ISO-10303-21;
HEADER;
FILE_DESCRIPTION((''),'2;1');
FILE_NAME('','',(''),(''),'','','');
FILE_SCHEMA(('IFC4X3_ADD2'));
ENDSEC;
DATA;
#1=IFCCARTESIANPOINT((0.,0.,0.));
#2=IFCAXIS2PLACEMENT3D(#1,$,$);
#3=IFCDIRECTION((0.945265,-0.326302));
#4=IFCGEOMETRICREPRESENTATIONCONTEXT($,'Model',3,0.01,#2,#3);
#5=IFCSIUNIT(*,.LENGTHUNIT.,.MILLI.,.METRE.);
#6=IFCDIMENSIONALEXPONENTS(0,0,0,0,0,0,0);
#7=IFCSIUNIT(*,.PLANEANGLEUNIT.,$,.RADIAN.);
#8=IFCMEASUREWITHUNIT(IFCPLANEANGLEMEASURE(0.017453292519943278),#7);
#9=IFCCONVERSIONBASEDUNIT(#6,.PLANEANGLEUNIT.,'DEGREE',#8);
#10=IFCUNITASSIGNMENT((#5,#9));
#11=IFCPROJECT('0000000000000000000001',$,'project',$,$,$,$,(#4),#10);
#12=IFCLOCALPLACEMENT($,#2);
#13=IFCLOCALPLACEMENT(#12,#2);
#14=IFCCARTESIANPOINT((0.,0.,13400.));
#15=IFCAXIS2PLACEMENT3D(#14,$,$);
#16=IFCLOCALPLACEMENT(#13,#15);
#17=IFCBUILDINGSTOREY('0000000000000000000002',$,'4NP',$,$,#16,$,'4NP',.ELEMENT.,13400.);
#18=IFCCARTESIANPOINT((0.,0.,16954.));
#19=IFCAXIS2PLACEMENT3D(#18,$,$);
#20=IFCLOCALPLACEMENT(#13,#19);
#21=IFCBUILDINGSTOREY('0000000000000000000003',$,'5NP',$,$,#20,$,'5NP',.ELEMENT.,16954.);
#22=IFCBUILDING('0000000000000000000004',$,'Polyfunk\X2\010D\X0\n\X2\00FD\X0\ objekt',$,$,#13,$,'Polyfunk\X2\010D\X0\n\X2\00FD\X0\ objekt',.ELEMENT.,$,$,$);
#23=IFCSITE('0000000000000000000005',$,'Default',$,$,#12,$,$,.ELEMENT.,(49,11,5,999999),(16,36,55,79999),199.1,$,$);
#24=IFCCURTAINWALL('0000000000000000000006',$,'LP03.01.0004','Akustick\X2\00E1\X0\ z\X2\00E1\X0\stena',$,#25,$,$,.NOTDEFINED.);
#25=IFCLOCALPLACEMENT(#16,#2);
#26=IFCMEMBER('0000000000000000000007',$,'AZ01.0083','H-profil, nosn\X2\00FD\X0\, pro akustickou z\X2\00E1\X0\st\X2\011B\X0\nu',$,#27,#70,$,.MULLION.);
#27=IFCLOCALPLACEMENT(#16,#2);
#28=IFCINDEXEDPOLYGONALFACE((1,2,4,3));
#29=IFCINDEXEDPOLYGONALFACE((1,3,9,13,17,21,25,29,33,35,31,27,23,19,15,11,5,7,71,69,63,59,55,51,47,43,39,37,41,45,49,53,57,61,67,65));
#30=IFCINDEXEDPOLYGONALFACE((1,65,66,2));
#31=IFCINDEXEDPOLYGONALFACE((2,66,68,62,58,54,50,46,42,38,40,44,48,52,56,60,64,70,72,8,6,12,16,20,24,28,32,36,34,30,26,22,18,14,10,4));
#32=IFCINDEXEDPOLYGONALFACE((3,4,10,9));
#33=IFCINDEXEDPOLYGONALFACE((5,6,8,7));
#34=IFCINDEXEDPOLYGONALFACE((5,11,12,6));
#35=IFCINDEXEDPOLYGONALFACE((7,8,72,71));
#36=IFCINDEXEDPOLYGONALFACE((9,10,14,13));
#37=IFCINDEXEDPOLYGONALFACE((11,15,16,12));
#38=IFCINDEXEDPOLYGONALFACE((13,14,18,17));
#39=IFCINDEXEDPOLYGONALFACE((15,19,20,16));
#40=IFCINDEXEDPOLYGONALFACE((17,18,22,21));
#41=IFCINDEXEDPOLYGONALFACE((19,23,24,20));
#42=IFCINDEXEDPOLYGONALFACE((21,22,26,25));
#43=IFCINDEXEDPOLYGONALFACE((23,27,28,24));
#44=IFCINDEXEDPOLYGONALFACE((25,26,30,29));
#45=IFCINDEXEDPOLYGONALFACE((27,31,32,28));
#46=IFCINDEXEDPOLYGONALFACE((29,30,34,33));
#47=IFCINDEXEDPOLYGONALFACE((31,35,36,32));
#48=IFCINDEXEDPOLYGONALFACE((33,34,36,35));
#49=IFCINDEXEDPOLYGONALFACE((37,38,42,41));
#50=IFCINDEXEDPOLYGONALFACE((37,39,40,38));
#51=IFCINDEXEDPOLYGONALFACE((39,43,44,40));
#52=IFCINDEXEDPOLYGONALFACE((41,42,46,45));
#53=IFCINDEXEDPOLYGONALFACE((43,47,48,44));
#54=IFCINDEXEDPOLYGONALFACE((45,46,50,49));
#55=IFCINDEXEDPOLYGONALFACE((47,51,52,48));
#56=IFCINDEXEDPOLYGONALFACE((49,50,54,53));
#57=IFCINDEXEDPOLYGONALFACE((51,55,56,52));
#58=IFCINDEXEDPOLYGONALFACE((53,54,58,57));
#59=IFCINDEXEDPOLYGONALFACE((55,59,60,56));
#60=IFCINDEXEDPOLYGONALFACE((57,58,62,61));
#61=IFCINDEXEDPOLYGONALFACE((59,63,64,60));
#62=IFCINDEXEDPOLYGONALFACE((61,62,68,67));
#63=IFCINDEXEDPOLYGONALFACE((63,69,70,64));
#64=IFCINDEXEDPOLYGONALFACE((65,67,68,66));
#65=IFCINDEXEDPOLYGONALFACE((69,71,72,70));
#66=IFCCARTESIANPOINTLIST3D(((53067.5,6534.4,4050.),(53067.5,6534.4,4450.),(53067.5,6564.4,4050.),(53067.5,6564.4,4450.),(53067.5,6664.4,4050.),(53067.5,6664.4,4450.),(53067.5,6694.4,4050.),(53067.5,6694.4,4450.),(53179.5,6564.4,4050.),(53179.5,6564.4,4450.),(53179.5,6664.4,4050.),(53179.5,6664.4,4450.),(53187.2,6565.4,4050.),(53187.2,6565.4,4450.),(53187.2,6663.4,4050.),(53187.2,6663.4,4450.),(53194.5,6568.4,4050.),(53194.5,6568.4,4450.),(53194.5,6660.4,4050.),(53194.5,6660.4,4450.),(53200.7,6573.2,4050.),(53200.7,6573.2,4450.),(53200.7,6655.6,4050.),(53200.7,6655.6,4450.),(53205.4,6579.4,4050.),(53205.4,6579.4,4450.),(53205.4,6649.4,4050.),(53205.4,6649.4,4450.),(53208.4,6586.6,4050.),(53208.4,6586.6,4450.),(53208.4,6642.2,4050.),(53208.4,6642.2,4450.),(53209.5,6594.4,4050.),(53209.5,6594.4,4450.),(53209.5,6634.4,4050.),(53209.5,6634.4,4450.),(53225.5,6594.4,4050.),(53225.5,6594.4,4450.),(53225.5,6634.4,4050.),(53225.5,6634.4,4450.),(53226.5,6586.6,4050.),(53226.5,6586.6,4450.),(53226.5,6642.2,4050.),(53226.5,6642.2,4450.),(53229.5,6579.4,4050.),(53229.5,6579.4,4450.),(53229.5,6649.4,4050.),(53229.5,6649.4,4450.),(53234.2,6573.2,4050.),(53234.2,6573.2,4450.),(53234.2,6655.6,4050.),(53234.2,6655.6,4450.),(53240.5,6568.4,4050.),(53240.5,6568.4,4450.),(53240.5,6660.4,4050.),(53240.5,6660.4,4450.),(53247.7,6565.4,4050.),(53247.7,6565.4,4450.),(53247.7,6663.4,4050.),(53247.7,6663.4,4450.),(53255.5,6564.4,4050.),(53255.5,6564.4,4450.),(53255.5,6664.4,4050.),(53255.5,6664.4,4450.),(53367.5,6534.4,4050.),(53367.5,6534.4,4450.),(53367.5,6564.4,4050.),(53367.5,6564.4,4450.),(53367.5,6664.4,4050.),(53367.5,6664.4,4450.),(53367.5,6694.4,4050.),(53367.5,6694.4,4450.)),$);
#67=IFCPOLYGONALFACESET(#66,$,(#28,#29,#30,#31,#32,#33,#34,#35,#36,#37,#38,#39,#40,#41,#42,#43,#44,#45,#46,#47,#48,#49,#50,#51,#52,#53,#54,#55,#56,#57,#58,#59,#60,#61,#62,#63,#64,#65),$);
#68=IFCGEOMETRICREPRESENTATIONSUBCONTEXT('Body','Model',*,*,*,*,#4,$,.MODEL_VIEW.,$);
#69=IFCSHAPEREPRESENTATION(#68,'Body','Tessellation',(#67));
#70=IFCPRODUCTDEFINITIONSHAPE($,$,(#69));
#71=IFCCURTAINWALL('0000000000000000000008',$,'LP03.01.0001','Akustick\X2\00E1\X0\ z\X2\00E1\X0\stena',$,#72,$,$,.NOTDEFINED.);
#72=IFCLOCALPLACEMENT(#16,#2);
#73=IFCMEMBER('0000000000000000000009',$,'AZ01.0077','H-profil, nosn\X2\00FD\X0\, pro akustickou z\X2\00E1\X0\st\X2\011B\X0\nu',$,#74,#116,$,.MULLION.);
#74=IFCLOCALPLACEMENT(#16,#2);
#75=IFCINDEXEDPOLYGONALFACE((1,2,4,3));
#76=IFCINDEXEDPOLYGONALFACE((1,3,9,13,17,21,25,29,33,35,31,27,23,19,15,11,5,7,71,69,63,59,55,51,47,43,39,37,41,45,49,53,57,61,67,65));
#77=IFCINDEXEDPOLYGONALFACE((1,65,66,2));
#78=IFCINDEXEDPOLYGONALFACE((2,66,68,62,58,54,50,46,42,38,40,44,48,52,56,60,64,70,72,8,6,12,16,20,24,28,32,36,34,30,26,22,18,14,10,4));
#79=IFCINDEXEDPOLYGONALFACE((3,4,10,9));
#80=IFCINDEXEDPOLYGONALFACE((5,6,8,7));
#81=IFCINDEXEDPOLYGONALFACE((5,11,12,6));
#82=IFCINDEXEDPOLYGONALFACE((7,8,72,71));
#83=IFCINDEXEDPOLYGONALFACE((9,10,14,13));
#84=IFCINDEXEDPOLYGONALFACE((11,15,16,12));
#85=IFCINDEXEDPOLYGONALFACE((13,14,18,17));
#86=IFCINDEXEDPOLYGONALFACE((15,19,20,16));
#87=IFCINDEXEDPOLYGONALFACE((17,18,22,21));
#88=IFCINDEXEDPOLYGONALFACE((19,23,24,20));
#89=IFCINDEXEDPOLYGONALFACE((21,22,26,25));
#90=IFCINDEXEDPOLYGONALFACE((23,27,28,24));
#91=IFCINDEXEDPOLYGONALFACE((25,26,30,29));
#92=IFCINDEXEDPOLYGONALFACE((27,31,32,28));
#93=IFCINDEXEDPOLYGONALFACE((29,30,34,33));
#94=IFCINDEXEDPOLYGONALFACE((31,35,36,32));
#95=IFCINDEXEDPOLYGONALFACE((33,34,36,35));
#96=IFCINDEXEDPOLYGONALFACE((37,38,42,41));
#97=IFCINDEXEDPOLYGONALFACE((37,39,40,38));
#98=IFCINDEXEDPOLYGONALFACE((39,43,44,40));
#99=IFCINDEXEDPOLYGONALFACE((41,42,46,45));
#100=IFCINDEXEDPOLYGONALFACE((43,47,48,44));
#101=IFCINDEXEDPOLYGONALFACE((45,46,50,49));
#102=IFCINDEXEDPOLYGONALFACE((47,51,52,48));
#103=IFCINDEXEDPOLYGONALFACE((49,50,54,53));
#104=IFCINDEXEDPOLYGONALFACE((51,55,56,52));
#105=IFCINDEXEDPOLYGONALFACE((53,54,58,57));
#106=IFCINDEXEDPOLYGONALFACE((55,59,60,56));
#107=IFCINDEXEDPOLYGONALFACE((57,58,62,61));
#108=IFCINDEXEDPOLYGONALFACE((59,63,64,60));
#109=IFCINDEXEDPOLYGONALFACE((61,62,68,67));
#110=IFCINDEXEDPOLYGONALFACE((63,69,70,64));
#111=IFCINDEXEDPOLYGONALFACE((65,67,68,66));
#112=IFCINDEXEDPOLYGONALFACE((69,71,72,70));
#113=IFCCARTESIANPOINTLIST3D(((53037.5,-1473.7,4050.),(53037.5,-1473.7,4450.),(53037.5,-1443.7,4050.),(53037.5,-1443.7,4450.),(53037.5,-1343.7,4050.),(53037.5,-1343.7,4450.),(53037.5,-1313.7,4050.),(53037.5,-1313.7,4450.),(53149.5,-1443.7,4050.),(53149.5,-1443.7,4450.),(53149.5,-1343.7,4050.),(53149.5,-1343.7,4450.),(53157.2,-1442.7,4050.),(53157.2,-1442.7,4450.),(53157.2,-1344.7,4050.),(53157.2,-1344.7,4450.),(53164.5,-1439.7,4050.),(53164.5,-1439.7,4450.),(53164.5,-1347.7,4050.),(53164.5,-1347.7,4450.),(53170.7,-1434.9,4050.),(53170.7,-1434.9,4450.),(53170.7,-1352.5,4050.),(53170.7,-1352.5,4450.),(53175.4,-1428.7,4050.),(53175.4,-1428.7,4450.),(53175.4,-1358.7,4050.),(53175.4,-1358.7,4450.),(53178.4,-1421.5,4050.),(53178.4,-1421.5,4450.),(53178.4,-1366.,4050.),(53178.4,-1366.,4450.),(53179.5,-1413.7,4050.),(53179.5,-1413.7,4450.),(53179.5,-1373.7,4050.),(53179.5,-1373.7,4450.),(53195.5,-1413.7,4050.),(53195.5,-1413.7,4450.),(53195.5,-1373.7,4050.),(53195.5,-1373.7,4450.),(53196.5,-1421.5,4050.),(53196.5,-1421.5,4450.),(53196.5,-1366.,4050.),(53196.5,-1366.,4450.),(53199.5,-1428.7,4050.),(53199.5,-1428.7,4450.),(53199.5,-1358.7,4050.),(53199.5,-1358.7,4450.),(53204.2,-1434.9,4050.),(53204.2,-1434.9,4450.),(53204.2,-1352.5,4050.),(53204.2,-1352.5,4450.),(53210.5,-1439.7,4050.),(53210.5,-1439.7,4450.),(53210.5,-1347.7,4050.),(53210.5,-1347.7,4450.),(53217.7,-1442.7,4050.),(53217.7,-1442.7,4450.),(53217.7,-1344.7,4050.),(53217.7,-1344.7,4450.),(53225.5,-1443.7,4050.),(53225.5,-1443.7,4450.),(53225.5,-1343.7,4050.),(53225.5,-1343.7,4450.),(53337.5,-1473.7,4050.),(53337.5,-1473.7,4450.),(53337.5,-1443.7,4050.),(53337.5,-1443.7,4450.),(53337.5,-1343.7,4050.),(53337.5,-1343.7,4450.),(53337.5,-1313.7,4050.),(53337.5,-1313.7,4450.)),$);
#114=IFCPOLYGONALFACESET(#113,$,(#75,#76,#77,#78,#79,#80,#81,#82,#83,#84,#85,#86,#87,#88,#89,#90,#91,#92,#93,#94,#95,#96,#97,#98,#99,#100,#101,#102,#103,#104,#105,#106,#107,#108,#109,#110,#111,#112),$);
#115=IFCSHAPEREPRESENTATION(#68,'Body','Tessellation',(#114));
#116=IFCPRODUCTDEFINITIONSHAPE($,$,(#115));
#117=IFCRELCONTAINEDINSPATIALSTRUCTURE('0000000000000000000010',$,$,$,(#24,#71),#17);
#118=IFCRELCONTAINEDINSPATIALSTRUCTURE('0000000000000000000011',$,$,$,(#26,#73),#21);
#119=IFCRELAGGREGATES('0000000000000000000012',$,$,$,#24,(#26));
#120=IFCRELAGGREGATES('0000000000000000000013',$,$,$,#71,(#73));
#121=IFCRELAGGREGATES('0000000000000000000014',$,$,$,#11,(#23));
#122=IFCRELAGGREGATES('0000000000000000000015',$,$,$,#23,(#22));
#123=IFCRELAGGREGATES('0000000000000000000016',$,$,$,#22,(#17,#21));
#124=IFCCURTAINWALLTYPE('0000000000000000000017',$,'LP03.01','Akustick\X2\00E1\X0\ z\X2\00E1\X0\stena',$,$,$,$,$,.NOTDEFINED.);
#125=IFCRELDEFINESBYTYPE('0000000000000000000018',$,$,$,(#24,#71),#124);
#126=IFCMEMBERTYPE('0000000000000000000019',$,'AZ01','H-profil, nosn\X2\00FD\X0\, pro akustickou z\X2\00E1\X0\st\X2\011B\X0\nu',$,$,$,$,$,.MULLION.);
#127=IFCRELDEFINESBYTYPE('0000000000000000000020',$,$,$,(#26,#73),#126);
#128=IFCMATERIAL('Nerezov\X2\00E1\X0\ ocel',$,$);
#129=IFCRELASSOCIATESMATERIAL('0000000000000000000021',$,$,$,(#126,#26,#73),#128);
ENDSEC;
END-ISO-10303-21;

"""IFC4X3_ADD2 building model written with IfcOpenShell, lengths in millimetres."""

from ifc_helpers import new_model, entity, si_unit, converted_unit, direction, frame, frame_2d, origin, place, context, subcontext, project, spatial, polyline, circle_curve, parameter, trimmed, segment, composite_curve, outline, extrude, source, transform, mapped, material, material_profile, profile_set, profile_usage, type_object, element, aggregate, save


model = new_model("IFC4X3_ADD2")

# Units and contexts
model_context = context("Model", 3, precision=0.01, world=origin(), true_north=direction((0.945265, -0.326302)))
body_context = subcontext(model_context, "Body", "Model", "MODEL_VIEW")
ifc_project = project(units=[si_unit("LENGTHUNIT", "METRE", prefix="MILLI"), converted_unit("PLANEANGLEUNIT", "DEGREE", entity("IfcPlaneAngleMeasure", 0.017453292519943278), si_unit("PLANEANGLEUNIT", "RADIAN"), dimensions=[0, 0, 0, 0, 0, 0, 0])], contexts=[model_context])

# Site, building, storey
site_placement = place(None, origin())
site = spatial("IfcSite", under=ifc_project, at=site_placement, Name="Default", CompositionType="ELEMENT", RefLatitude=(49, 11, 5, 999999), RefLongitude=(16, 36, 55, 79999), RefElevation=199.1)
building_placement = place(site_placement, origin())
building = spatial("IfcBuilding", under=site, at=building_placement, Name="Polyfunkčný objekt", LongName="Polyfunkčný objekt", CompositionType="ELEMENT")
storey_1_placement = place(building_placement, frame((0.0, 0.0, 13400.0)))
storey_1 = spatial("IfcBuildingStorey", under=building, at=storey_1_placement, Name="4NP", LongName="4NP", CompositionType="ELEMENT", Elevation=13400.0)

# Curtain wall
curtain_wall_type = type_object("IfcCurtainWallType", Name="LP03.01", Description="Akustická zástena", PredefinedType="NOTDEFINED")
curtain_wall_1_placement = place(storey_1_placement, frame((0.0, 0.0, -13400.0)))
curtain_wall_1 = element("IfcCurtainWall", 1, at=curtain_wall_1_placement, inside=storey_1, type_object=curtain_wall_type, Name="LP03.01.0004", Description="Akustická zástena", PredefinedType="NOTDEFINED")

# Shared definitions
storey_2_placement = place(building_placement, frame((0.0, 0.0, 16954.0)))
storey_2 = spatial("IfcBuildingStorey", under=building, at=storey_2_placement, Name="5NP", LongName="5NP", CompositionType="ELEMENT", Elevation=16954.0)

# Member
ifc_material_1 = material(Name="Nerezová ocel")
ifc_material_profile = material_profile(ifc_material_1, outline(composite_curve([segment(polyline([(50.0, -150.0), (80.0, -150.0)]), True, "CONTINUOUS"), segment(polyline([(80.0, -150.0), (80.0, 150.0)]), True, "CONTINUOUS"), segment(polyline([(80.0, 150.0), (50.0, 150.0)]), True, "CONTINUOUS"), segment(polyline([(50.0, 150.0), (50.0, 38.0)]), True, "CONTINUOUS"), segment(trimmed(circle_curve(frame_2d((20.0, 38.0), x_axis=(0.0, 1.0)), 30.0), [parameter(180.0)], [parameter(270.0)], True, "PARAMETER"), False, "CONTINUOUS"), segment(polyline([(20.0, 8.0), (-20.0, 8.0)]), True, "CONTINUOUS"), segment(trimmed(circle_curve(frame_2d((-20.0, 38.0), x_axis=(0.0, 1.0)), 30.0), [parameter(90.0)], [parameter(180.0)], True, "PARAMETER"), False, "CONTINUOUS"), segment(polyline([(-50.0, 38.0), (-50.0, 150.0)]), True, "CONTINUOUS"), segment(polyline([(-50.0, 150.0), (-80.0, 150.0)]), True, "CONTINUOUS"), segment(polyline([(-80.0, 150.0), (-80.0, -150.0)]), True, "CONTINUOUS"), segment(polyline([(-80.0, -150.0), (-50.0, -150.0)]), True, "CONTINUOUS"), segment(polyline([(-50.0, -150.0), (-50.0, -38.0)]), True, "CONTINUOUS"), segment(trimmed(circle_curve(frame_2d((-20.0, -38.0), x_axis=(0.0, 1.0)), 30.0), [parameter(0.0)], [parameter(90.0)], True, "PARAMETER"), False, "CONTINUOUS"), segment(polyline([(-20.0, -8.0), (20.0, -8.0)]), True, "CONTINUOUS"), segment(trimmed(circle_curve(frame_2d((20.0, -38.0), x_axis=(0.0, 1.0)), 30.0), [parameter(270.0)], [parameter(0.0)], True, "PARAMETER"), False, "CONTINUOUS"), segment(polyline([(50.0, -38.0), (50.0, -150.0)]), True, "CONTINUOUS")], self_intersect=False)), Name="Profil zástena")
ifc_profile_set = profile_set([ifc_material_profile], Name="Profil zástena")
ifc_profile_usage = profile_usage(ifc_profile_set)
member_type = type_object("IfcMemberType", Name="AZ01", Description="H-profil, nosný, pro akustickou zástěnu", PredefinedType="MULLION", material=ifc_profile_set)
shared_shape_1 = source(origin(), body_context, "Body", "SweptSolid", [
    extrude(outline(composite_curve([segment(polyline([(50.0, -150.0), (80.0, -150.0)]), True, "CONTINUOUS"), segment(polyline([(80.0, -150.0), (80.0, 150.0)]), True, "CONTINUOUS"), segment(polyline([(80.0, 150.0), (50.0, 150.0)]), True, "CONTINUOUS"), segment(polyline([(50.0, 150.0), (50.0, 38.0)]), True, "CONTINUOUS"), segment(trimmed(circle_curve(frame_2d((20.0, 38.0), x_axis=(0.0, 1.0)), 30.0), [parameter(180.0)], [parameter(270.0)], True, "PARAMETER"), False, "CONTINUOUS"), segment(polyline([(20.0, 8.0), (-20.0, 8.0)]), True, "CONTINUOUS"), segment(trimmed(circle_curve(frame_2d((-20.0, 38.0), x_axis=(0.0, 1.0)), 30.0), [parameter(90.0)], [parameter(180.0)], True, "PARAMETER"), False, "CONTINUOUS"), segment(polyline([(-50.0, 38.0), (-50.0, 150.0)]), True, "CONTINUOUS"), segment(polyline([(-50.0, 150.0), (-80.0, 150.0)]), True, "CONTINUOUS"), segment(polyline([(-80.0, 150.0), (-80.0, -150.0)]), True, "CONTINUOUS"), segment(polyline([(-80.0, -150.0), (-50.0, -150.0)]), True, "CONTINUOUS"), segment(polyline([(-50.0, -150.0), (-50.0, -38.0)]), True, "CONTINUOUS"), segment(trimmed(circle_curve(frame_2d((-20.0, -38.0), x_axis=(0.0, 1.0)), 30.0), [parameter(0.0)], [parameter(90.0)], True, "PARAMETER"), False, "CONTINUOUS"), segment(polyline([(-20.0, -8.0), (20.0, -8.0)]), True, "CONTINUOUS"), segment(trimmed(circle_curve(frame_2d((20.0, -38.0), x_axis=(0.0, 1.0)), 30.0), [parameter(270.0)], [parameter(0.0)], True, "PARAMETER"), False, "CONTINUOUS"), segment(polyline([(50.0, -38.0), (50.0, -150.0)]), True, "CONTINUOUS")], self_intersect=False)), frame((0.0, 0.0, -400.0), z_axis=(0.0, 0.0, 1.0), x_axis=(0.0, -1.0, 0.0)), (0.0, 0.0, 1.0), 400.0),
])
member_1_placement = place(curtain_wall_1_placement, frame((53217.5, 6614.4, 17450.0), z_axis=(0.0, 0.0, -1.0), x_axis=(1.0, 0.0, 0.0)))
member_1 = element("IfcMember", 2, at=member_1_placement, inside=storey_2, type_object=member_type, material=ifc_profile_usage, Name="AZ01.0083", Description="H-profil, nosný, pro akustickou zástěnu", PredefinedType="MULLION", context=body_context, shape_type="MappedRepresentation", body=[
    mapped(shared_shape_1, transform((0.0, 0.0, 0.0), scale=1.0)),
])

# Curtain wall, member
curtain_wall_2_placement = place(storey_1_placement, frame((0.0, 0.0, -13400.0)))
curtain_wall_2 = element("IfcCurtainWall", 3, at=curtain_wall_2_placement, inside=storey_1, type_object=curtain_wall_type, Name="LP03.01.0001", Description="Akustická zástena", PredefinedType="NOTDEFINED")
member_2_placement = place(curtain_wall_2_placement, frame((53187.5, -1393.7, 17450.0), z_axis=(0.0, 0.0, -1.0), x_axis=(1.0, 0.0, 0.0)))
member_2 = element("IfcMember", 4, at=member_2_placement, inside=storey_2, type_object=member_type, material=ifc_profile_usage, Name="AZ01.0077", Description="H-profil, nosný, pro akustickou zástěnu", PredefinedType="MULLION", context=body_context, shape_type="MappedRepresentation", body=[
    mapped(shared_shape_1, transform((0.0, 0.0, 0.0), scale=1.0)),
])

aggregate(curtain_wall_1, [member_1])
aggregate(curtain_wall_2, [member_2])

save(model, "model.ifc")
